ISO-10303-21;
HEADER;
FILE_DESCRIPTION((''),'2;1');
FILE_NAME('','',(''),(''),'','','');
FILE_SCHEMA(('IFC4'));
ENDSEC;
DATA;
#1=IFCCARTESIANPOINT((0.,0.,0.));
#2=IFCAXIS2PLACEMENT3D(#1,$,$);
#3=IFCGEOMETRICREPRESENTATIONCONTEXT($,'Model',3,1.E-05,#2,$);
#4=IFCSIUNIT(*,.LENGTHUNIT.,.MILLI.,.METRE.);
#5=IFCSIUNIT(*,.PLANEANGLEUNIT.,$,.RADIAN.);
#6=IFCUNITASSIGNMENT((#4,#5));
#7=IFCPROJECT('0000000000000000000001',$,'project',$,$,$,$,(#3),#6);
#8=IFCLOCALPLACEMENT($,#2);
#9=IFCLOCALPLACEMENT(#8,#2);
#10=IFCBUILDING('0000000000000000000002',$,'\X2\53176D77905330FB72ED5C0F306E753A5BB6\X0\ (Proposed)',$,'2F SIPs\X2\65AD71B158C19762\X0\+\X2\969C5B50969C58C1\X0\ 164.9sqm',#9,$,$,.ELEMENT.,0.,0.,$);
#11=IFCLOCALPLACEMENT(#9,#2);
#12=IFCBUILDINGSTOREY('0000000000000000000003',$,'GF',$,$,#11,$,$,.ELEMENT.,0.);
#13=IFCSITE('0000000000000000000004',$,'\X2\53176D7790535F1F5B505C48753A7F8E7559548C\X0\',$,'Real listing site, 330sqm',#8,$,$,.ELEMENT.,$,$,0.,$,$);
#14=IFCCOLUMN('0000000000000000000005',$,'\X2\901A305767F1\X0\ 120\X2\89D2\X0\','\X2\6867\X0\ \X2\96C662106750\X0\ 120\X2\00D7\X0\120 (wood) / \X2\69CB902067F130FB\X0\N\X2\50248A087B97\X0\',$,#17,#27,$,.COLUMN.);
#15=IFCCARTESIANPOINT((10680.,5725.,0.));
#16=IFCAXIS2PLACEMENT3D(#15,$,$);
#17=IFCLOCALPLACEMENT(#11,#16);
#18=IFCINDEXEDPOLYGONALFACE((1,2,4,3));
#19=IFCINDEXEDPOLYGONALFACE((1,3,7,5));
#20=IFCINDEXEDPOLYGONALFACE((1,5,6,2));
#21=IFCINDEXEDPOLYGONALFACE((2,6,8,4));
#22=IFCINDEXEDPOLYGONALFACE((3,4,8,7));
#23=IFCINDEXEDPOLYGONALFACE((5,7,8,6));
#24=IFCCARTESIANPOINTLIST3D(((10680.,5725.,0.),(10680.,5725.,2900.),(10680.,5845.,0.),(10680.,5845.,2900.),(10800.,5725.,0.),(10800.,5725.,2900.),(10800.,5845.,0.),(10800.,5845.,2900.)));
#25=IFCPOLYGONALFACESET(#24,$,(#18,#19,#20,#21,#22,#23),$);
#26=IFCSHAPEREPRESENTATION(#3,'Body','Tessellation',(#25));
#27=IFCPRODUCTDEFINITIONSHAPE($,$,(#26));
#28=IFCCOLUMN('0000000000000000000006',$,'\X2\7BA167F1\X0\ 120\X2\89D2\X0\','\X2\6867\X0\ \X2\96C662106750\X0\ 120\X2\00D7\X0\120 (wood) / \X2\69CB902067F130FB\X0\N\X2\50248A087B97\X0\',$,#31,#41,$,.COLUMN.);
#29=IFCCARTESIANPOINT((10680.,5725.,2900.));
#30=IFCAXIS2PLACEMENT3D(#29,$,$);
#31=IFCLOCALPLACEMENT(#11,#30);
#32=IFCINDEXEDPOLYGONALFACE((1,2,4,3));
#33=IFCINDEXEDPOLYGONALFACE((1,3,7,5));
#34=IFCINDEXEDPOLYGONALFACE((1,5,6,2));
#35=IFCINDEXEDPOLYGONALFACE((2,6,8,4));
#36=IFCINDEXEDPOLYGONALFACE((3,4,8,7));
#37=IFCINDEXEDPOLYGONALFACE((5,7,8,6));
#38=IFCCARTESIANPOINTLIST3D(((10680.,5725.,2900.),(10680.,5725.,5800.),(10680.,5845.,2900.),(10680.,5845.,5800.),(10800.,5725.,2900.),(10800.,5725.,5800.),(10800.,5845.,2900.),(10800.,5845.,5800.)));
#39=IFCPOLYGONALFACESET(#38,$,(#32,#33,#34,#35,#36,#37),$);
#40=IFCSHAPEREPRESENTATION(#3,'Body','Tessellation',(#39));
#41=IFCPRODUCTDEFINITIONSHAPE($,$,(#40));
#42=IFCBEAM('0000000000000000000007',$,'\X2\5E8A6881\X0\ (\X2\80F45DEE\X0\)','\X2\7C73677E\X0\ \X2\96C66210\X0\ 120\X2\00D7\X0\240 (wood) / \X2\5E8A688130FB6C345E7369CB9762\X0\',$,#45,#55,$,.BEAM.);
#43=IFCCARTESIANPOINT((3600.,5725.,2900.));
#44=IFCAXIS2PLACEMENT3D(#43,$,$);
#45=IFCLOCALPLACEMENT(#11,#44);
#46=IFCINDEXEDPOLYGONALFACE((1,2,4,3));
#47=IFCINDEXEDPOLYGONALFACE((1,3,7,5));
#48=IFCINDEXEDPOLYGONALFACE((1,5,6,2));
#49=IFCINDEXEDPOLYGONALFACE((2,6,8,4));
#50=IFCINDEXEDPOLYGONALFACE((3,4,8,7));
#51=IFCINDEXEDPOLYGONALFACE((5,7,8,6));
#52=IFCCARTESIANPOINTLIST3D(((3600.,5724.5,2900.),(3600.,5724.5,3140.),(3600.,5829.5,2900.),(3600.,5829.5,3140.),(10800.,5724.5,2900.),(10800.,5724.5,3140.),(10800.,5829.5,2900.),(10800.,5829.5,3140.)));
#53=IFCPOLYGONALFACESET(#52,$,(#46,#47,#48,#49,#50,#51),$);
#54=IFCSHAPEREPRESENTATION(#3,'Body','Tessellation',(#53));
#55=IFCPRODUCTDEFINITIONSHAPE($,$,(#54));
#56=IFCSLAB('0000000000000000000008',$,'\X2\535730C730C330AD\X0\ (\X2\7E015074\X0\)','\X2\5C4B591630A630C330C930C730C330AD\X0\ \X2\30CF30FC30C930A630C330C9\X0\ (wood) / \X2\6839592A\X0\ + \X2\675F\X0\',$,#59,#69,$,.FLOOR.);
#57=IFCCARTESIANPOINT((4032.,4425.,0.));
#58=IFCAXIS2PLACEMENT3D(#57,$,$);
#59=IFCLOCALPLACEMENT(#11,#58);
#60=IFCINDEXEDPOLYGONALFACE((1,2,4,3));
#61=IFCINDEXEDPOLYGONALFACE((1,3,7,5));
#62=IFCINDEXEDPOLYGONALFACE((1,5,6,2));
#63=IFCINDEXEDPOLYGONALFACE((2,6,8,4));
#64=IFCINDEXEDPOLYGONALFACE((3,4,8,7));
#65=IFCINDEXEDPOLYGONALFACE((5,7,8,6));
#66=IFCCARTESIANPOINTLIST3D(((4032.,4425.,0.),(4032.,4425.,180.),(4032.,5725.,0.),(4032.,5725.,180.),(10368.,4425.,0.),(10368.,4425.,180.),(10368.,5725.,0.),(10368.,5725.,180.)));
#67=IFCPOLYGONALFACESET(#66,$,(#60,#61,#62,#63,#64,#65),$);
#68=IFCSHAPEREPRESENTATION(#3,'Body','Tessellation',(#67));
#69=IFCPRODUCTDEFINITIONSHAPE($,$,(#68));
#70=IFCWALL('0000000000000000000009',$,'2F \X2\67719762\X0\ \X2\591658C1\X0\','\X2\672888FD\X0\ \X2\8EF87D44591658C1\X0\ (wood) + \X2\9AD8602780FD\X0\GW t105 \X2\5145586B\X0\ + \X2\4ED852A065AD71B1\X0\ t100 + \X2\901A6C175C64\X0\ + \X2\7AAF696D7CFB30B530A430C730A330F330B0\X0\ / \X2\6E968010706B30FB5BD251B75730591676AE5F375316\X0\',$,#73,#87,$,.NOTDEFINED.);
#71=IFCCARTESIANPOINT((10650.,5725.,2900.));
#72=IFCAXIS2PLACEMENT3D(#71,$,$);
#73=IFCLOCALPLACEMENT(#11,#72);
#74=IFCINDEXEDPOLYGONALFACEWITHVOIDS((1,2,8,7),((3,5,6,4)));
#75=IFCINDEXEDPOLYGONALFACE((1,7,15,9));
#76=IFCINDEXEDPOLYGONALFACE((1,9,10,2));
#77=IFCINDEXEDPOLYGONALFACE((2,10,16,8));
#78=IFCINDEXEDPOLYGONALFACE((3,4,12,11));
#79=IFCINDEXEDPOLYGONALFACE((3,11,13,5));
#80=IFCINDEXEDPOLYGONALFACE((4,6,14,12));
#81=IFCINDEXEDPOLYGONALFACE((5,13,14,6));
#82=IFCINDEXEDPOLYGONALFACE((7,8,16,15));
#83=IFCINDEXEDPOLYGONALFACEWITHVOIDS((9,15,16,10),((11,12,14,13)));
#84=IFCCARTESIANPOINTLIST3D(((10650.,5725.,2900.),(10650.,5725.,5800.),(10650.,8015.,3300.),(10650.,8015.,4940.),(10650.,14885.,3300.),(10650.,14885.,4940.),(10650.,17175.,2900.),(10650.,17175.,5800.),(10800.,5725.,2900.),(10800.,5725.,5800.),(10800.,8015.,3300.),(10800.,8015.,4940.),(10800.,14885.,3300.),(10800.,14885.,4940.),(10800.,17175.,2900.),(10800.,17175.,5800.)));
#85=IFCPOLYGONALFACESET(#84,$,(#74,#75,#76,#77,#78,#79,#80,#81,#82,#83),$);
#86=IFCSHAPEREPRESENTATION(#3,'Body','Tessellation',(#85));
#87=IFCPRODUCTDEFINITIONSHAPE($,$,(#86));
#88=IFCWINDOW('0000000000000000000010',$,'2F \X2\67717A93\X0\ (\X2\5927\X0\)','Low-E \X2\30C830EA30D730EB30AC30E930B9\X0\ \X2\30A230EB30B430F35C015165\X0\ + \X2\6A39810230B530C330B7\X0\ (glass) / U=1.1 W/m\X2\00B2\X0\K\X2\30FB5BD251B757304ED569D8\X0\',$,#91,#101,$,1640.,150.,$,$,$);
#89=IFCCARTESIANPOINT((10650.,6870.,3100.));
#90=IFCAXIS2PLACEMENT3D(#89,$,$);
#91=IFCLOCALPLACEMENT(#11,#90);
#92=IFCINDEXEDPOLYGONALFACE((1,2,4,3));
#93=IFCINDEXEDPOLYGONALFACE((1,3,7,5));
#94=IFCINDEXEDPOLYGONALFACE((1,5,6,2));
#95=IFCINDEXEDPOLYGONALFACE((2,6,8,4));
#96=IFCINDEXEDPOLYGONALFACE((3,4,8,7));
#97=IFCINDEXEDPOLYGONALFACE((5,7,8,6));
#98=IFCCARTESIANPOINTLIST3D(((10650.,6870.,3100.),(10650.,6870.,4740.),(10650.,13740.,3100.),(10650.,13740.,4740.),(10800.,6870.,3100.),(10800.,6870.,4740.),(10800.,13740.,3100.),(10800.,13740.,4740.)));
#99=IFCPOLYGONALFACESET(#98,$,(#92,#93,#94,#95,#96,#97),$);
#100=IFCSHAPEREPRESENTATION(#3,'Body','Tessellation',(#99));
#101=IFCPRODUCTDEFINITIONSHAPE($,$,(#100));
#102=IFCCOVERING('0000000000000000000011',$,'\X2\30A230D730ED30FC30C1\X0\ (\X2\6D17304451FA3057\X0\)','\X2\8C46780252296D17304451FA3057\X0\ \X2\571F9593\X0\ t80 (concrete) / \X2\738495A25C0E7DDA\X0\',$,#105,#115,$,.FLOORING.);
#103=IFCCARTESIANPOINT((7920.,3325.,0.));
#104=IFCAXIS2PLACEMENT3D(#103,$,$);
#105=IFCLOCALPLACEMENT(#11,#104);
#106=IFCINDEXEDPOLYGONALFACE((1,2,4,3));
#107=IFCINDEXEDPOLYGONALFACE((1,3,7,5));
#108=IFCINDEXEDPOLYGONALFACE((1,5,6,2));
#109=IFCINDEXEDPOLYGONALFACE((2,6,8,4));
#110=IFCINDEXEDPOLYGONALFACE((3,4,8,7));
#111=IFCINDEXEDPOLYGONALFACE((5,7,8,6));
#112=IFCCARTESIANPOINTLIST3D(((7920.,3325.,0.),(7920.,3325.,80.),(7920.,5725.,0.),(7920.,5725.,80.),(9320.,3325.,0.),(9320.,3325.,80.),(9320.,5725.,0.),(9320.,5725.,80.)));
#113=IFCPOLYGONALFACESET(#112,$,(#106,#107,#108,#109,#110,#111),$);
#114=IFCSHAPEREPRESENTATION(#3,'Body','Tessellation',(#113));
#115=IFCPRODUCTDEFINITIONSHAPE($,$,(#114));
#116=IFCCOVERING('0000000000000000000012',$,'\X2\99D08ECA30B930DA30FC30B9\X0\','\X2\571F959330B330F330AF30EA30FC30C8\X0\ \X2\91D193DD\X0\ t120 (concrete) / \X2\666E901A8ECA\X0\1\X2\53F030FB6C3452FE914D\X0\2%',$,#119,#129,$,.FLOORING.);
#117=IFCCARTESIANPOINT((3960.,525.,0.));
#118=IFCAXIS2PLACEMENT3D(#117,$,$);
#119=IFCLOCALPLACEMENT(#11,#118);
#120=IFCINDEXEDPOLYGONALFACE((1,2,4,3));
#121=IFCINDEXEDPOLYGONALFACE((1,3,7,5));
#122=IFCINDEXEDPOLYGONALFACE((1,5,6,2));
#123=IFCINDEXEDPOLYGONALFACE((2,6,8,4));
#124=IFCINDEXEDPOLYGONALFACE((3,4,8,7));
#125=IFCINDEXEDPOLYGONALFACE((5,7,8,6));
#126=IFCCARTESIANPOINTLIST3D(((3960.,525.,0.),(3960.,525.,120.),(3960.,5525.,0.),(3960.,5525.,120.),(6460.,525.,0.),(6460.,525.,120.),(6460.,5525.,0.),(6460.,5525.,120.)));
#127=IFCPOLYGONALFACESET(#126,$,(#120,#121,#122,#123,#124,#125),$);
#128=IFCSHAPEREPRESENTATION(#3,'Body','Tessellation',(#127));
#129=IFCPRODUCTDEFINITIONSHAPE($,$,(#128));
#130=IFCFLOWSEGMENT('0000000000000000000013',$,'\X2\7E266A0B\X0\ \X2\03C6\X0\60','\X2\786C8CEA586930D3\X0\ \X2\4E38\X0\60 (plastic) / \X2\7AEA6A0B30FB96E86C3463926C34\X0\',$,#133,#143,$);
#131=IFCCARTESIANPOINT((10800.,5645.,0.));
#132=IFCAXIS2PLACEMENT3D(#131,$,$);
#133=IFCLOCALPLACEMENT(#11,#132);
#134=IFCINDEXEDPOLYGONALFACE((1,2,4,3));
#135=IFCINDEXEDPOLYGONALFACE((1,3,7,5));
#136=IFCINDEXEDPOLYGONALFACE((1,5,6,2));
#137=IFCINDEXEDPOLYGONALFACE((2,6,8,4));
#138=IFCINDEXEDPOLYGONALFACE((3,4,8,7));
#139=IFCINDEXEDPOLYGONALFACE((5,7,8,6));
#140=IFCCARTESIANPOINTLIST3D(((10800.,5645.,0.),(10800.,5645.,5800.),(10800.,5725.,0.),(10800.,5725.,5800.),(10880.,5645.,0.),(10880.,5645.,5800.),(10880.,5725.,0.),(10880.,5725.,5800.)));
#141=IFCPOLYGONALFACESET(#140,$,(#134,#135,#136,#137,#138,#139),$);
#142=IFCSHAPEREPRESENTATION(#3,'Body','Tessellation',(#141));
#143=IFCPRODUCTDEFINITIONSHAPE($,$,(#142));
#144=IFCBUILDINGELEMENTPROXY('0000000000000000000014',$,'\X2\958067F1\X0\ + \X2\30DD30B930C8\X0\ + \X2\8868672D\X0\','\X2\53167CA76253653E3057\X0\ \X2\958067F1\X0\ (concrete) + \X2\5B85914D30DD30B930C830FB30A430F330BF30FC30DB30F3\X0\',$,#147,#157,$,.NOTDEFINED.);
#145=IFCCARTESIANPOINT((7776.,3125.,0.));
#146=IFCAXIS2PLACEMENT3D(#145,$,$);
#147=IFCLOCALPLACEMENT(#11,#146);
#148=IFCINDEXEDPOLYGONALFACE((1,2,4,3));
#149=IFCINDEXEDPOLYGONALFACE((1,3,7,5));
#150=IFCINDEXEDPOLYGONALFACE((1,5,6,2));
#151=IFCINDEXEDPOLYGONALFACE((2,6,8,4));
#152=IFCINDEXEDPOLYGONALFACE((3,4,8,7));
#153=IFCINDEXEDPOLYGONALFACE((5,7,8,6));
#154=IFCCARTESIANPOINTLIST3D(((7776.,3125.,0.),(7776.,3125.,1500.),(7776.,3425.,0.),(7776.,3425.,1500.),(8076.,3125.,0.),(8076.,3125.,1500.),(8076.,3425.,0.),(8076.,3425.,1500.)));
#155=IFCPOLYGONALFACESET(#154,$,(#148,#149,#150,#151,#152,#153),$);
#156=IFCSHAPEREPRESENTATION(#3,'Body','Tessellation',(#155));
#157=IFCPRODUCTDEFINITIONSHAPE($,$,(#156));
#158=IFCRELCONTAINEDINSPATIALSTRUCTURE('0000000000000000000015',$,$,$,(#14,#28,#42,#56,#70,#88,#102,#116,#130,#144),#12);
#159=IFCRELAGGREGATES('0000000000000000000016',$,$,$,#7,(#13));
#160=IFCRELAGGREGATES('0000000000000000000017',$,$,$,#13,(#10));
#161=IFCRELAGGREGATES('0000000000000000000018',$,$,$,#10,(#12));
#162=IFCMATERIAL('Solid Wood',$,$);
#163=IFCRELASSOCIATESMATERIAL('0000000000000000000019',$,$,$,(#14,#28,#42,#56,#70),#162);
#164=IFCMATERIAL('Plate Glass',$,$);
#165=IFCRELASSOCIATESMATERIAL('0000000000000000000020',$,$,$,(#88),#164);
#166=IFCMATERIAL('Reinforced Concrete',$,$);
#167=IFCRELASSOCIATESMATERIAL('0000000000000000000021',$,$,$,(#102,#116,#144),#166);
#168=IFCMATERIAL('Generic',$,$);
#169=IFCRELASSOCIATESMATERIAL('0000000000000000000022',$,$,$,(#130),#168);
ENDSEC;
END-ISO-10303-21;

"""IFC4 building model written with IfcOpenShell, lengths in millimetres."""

from ifc_helpers import new_model, si_unit, frame, frame_2d, origin, place, context, project, spatial, rectangle, extrude, material, element, fill, save


model = new_model("IFC4")

# Units and contexts
model_context = context("Model", 3, precision=1e-05, world=origin())
ifc_project = project(units=[si_unit("LENGTHUNIT", "METRE", prefix="MILLI"), si_unit("PLANEANGLEUNIT", "RADIAN")], contexts=[model_context])

# Site, building, storey
site_placement = place(None, origin())
site = spatial("IfcSite", under=ifc_project, at=site_placement, Name="北海道弟子屈町美留和", ObjectType="Real listing site, 330sqm", CompositionType="ELEMENT", RefElevation=0.0)
building_placement = place(site_placement, origin())
building = spatial("IfcBuilding", under=site, at=building_placement, Name="北海道・狭小の町家 (Proposed)", ObjectType="2F SIPs断熱壁面+障子障壁 164.9sqm", CompositionType="ELEMENT", ElevationOfRefHeight=0.0, ElevationOfTerrain=0.0)
storey_placement = place(building_placement, origin())
storey = spatial("IfcBuildingStorey", under=building, at=storey_placement, Name="GF", CompositionType="ELEMENT", Elevation=0.0)

# Columns
ifc_material_1 = material(Name="Solid Wood")
column_1_placement = place(storey_placement, frame((10680.0, 5725.0, 0.0)))
element("IfcColumn", 1, at=column_1_placement, inside=storey, material=ifc_material_1, Name="通し柱 120角", Description="桧 集成材 120×120 (wood) / 構造柱・N値計算", PredefinedType="COLUMN", context=model_context, shape_type="SweptSolid", body=[
    extrude(rectangle(XDim=120.0, YDim=120.0, at=frame_2d((60.0, 60.0))), frame((10680.0, 5725.0, 0.0)), (0.0, 0.0, 1.0), 2900.0),
])
column_2_placement = place(storey_placement, frame((10680.0, 5725.0, 2900.0)))
element("IfcColumn", 2, at=column_2_placement, inside=storey, material=ifc_material_1, Name="管柱 120角", Description="桧 集成材 120×120 (wood) / 構造柱・N値計算", PredefinedType="COLUMN", context=model_context, shape_type="SweptSolid", body=[
    extrude(rectangle(XDim=120.0, YDim=120.0, at=frame_2d((60.0, 60.0))), frame((10680.0, 5725.0, 2900.0)), (0.0, 0.0, 1.0), 2900.0),
])

# Beam
beam_1_placement = place(storey_placement, frame((3600.0, 5725.0, 2900.0)))
element("IfcBeam", 3, at=beam_1_placement, inside=storey, material=ifc_material_1, Name="床梁 (胴差)", Description="米松 集成 120×240 (wood) / 床梁・水平構面", PredefinedType="BEAM", context=model_context, shape_type="SweptSolid", body=[
    extrude(rectangle(XDim=7200.0, YDim=105.0, at=frame_2d((3600.0, 52.0))), frame((3600.0, 5725.0, 2900.0)), (0.0, 0.0, 1.0), 240.0),
])

# Slab
slab_placement = place(storey_placement, frame((4032.0, 4425.0, 0.0)))
element("IfcSlab", 4, at=slab_placement, inside=storey, material=ifc_material_1, Name="南デッキ (縁側)", Description="屋外ウッドデッキ ハードウッド (wood) / 根太 + 束", PredefinedType="FLOOR", context=model_context, shape_type="SweptSolid", body=[
    extrude(rectangle(XDim=6336.0, YDim=1300.0, at=frame_2d((3168.0, 650.0))), frame((4032.0, 4425.0, 0.0)), (0.0, 0.0, 1.0), 180.0),
])

# Wall, opening, window
ifc_material_2 = material(Name="Plate Glass")
wall_1_placement = place(storey_placement, frame((10650.0, 5725.0, 2900.0)))
wall_1 = element("IfcWall", 5, at=wall_1_placement, inside=storey, material=ifc_material_1, Name="2F 東面 外壁", Description="木製 軸組外壁 (wood) + 高性能GW t105 充填 + 付加断熱 t100 + 通気層 + 窯業系サイディング / 準耐火・寒冷地外皮強化", PredefinedType="NOTDEFINED", context=model_context, shape_type="SweptSolid", body=[
    extrude(rectangle(XDim=150.0, YDim=11450.0, at=frame_2d((75.0, 5725.0))), frame((10650.0, 5725.0, 2900.0)), (0.0, 0.0, 1.0), 2900.0),
])
opening_1_placement = place(storey_placement, frame((10650.0, 6870.0, 3100.0)))
opening_1 = element("IfcOpeningElement", 6, at=opening_1_placement, cuts=wall_1, PredefinedType="NOTDEFINED", context=model_context, shape_type="SweptSolid", body=[
    extrude(rectangle(XDim=150.0, YDim=6870.0, at=frame_2d((75.0, 3435.0))), frame((10650.0, 6870.0, 3100.0)), (0.0, 0.0, 1.0), 1640.0),
])
window_1_placement = place(storey_placement, frame((10650.0, 6870.0, 3100.0)))
window_1 = element("IfcWindow", 7, at=window_1_placement, inside=storey, material=ifc_material_2, Name="2F 東窓 (大)", Description="Low-E トリプルガラス アルゴン封入 + 樹脂サッシ (glass) / U=1.1 W/m²K・寒冷地仕様", OverallHeight=1640.0, OverallWidth=150.0, context=model_context, shape_type="SweptSolid", body=[
    extrude(rectangle(XDim=150.0, YDim=6870.0, at=frame_2d((75.0, 3435.0))), frame((10650.0, 6870.0, 3100.0)), (0.0, 0.0, 1.0), 1640.0),
])
fill(opening_1, window_1)

# Coverings
ifc_material_3 = material(Name="Reinforced Concrete")
covering_1_placement = place(storey_placement, frame((7920.0, 3325.0, 0.0)))
element("IfcCovering", 8, at=covering_1_placement, inside=storey, material=ifc_material_3, Name="アプローチ (洗い出し)", Description="豆砂利洗い出し 土間 t80 (concrete) / 玄関導線", PredefinedType="FLOORING", context=model_context, shape_type="SweptSolid", body=[
    extrude(rectangle(XDim=1400.0, YDim=2400.0, at=frame_2d((700.0, 1200.0))), frame((7920.0, 3325.0, 0.0)), (0.0, 0.0, 1.0), 80.0),
])
covering_2_placement = place(storey_placement, frame((3960.0, 525.0, 0.0)))
element("IfcCovering", 9, at=covering_2_placement, inside=storey, material=ifc_material_3, Name="駐車スペース", Description="土間コンクリート 金鏝 t120 (concrete) / 普通車1台・水勾配2%", PredefinedType="FLOORING", context=model_context, shape_type="SweptSolid", body=[
    extrude(rectangle(XDim=2500.0, YDim=5000.0, at=frame_2d((1250.0, 2500.0))), frame((3960.0, 525.0, 0.0)), (0.0, 0.0, 1.0), 120.0),
])

# Flow segment
ifc_material_4 = material(Name="Generic")
flow_segment_placement = place(storey_placement, frame((10800.0, 5645.0, 0.0)))
element("IfcFlowSegment", 10, at=flow_segment_placement, inside=storey, material=ifc_material_4, Name="縦樋 φ60", Description="硬質塩ビ 丸60 (plastic) / 竪樋・雨水排水", context=model_context, shape_type="SweptSolid", body=[
    extrude(rectangle(XDim=80.0, YDim=80.0, at=frame_2d((40.0, 40.0))), frame((10800.0, 5645.0, 0.0)), (0.0, 0.0, 1.0), 5800.0),
])

# Building element proxy
proxy_placement = place(storey_placement, frame((7776.0, 3125.0, 0.0)))
element("IfcBuildingElementProxy", 11, at=proxy_placement, inside=storey, material=ifc_material_3, Name="門柱 + ポスト + 表札", Description="化粧打放し 門柱 (concrete) + 宅配ポスト・インターホン", PredefinedType="NOTDEFINED", context=model_context, shape_type="SweptSolid", body=[
    extrude(rectangle(XDim=300.0, YDim=300.0, at=frame_2d((150.0, 150.0))), frame((7776.0, 3125.0, 0.0)), (0.0, 0.0, 1.0), 1500.0),
])

save(model, "model.ifc")
